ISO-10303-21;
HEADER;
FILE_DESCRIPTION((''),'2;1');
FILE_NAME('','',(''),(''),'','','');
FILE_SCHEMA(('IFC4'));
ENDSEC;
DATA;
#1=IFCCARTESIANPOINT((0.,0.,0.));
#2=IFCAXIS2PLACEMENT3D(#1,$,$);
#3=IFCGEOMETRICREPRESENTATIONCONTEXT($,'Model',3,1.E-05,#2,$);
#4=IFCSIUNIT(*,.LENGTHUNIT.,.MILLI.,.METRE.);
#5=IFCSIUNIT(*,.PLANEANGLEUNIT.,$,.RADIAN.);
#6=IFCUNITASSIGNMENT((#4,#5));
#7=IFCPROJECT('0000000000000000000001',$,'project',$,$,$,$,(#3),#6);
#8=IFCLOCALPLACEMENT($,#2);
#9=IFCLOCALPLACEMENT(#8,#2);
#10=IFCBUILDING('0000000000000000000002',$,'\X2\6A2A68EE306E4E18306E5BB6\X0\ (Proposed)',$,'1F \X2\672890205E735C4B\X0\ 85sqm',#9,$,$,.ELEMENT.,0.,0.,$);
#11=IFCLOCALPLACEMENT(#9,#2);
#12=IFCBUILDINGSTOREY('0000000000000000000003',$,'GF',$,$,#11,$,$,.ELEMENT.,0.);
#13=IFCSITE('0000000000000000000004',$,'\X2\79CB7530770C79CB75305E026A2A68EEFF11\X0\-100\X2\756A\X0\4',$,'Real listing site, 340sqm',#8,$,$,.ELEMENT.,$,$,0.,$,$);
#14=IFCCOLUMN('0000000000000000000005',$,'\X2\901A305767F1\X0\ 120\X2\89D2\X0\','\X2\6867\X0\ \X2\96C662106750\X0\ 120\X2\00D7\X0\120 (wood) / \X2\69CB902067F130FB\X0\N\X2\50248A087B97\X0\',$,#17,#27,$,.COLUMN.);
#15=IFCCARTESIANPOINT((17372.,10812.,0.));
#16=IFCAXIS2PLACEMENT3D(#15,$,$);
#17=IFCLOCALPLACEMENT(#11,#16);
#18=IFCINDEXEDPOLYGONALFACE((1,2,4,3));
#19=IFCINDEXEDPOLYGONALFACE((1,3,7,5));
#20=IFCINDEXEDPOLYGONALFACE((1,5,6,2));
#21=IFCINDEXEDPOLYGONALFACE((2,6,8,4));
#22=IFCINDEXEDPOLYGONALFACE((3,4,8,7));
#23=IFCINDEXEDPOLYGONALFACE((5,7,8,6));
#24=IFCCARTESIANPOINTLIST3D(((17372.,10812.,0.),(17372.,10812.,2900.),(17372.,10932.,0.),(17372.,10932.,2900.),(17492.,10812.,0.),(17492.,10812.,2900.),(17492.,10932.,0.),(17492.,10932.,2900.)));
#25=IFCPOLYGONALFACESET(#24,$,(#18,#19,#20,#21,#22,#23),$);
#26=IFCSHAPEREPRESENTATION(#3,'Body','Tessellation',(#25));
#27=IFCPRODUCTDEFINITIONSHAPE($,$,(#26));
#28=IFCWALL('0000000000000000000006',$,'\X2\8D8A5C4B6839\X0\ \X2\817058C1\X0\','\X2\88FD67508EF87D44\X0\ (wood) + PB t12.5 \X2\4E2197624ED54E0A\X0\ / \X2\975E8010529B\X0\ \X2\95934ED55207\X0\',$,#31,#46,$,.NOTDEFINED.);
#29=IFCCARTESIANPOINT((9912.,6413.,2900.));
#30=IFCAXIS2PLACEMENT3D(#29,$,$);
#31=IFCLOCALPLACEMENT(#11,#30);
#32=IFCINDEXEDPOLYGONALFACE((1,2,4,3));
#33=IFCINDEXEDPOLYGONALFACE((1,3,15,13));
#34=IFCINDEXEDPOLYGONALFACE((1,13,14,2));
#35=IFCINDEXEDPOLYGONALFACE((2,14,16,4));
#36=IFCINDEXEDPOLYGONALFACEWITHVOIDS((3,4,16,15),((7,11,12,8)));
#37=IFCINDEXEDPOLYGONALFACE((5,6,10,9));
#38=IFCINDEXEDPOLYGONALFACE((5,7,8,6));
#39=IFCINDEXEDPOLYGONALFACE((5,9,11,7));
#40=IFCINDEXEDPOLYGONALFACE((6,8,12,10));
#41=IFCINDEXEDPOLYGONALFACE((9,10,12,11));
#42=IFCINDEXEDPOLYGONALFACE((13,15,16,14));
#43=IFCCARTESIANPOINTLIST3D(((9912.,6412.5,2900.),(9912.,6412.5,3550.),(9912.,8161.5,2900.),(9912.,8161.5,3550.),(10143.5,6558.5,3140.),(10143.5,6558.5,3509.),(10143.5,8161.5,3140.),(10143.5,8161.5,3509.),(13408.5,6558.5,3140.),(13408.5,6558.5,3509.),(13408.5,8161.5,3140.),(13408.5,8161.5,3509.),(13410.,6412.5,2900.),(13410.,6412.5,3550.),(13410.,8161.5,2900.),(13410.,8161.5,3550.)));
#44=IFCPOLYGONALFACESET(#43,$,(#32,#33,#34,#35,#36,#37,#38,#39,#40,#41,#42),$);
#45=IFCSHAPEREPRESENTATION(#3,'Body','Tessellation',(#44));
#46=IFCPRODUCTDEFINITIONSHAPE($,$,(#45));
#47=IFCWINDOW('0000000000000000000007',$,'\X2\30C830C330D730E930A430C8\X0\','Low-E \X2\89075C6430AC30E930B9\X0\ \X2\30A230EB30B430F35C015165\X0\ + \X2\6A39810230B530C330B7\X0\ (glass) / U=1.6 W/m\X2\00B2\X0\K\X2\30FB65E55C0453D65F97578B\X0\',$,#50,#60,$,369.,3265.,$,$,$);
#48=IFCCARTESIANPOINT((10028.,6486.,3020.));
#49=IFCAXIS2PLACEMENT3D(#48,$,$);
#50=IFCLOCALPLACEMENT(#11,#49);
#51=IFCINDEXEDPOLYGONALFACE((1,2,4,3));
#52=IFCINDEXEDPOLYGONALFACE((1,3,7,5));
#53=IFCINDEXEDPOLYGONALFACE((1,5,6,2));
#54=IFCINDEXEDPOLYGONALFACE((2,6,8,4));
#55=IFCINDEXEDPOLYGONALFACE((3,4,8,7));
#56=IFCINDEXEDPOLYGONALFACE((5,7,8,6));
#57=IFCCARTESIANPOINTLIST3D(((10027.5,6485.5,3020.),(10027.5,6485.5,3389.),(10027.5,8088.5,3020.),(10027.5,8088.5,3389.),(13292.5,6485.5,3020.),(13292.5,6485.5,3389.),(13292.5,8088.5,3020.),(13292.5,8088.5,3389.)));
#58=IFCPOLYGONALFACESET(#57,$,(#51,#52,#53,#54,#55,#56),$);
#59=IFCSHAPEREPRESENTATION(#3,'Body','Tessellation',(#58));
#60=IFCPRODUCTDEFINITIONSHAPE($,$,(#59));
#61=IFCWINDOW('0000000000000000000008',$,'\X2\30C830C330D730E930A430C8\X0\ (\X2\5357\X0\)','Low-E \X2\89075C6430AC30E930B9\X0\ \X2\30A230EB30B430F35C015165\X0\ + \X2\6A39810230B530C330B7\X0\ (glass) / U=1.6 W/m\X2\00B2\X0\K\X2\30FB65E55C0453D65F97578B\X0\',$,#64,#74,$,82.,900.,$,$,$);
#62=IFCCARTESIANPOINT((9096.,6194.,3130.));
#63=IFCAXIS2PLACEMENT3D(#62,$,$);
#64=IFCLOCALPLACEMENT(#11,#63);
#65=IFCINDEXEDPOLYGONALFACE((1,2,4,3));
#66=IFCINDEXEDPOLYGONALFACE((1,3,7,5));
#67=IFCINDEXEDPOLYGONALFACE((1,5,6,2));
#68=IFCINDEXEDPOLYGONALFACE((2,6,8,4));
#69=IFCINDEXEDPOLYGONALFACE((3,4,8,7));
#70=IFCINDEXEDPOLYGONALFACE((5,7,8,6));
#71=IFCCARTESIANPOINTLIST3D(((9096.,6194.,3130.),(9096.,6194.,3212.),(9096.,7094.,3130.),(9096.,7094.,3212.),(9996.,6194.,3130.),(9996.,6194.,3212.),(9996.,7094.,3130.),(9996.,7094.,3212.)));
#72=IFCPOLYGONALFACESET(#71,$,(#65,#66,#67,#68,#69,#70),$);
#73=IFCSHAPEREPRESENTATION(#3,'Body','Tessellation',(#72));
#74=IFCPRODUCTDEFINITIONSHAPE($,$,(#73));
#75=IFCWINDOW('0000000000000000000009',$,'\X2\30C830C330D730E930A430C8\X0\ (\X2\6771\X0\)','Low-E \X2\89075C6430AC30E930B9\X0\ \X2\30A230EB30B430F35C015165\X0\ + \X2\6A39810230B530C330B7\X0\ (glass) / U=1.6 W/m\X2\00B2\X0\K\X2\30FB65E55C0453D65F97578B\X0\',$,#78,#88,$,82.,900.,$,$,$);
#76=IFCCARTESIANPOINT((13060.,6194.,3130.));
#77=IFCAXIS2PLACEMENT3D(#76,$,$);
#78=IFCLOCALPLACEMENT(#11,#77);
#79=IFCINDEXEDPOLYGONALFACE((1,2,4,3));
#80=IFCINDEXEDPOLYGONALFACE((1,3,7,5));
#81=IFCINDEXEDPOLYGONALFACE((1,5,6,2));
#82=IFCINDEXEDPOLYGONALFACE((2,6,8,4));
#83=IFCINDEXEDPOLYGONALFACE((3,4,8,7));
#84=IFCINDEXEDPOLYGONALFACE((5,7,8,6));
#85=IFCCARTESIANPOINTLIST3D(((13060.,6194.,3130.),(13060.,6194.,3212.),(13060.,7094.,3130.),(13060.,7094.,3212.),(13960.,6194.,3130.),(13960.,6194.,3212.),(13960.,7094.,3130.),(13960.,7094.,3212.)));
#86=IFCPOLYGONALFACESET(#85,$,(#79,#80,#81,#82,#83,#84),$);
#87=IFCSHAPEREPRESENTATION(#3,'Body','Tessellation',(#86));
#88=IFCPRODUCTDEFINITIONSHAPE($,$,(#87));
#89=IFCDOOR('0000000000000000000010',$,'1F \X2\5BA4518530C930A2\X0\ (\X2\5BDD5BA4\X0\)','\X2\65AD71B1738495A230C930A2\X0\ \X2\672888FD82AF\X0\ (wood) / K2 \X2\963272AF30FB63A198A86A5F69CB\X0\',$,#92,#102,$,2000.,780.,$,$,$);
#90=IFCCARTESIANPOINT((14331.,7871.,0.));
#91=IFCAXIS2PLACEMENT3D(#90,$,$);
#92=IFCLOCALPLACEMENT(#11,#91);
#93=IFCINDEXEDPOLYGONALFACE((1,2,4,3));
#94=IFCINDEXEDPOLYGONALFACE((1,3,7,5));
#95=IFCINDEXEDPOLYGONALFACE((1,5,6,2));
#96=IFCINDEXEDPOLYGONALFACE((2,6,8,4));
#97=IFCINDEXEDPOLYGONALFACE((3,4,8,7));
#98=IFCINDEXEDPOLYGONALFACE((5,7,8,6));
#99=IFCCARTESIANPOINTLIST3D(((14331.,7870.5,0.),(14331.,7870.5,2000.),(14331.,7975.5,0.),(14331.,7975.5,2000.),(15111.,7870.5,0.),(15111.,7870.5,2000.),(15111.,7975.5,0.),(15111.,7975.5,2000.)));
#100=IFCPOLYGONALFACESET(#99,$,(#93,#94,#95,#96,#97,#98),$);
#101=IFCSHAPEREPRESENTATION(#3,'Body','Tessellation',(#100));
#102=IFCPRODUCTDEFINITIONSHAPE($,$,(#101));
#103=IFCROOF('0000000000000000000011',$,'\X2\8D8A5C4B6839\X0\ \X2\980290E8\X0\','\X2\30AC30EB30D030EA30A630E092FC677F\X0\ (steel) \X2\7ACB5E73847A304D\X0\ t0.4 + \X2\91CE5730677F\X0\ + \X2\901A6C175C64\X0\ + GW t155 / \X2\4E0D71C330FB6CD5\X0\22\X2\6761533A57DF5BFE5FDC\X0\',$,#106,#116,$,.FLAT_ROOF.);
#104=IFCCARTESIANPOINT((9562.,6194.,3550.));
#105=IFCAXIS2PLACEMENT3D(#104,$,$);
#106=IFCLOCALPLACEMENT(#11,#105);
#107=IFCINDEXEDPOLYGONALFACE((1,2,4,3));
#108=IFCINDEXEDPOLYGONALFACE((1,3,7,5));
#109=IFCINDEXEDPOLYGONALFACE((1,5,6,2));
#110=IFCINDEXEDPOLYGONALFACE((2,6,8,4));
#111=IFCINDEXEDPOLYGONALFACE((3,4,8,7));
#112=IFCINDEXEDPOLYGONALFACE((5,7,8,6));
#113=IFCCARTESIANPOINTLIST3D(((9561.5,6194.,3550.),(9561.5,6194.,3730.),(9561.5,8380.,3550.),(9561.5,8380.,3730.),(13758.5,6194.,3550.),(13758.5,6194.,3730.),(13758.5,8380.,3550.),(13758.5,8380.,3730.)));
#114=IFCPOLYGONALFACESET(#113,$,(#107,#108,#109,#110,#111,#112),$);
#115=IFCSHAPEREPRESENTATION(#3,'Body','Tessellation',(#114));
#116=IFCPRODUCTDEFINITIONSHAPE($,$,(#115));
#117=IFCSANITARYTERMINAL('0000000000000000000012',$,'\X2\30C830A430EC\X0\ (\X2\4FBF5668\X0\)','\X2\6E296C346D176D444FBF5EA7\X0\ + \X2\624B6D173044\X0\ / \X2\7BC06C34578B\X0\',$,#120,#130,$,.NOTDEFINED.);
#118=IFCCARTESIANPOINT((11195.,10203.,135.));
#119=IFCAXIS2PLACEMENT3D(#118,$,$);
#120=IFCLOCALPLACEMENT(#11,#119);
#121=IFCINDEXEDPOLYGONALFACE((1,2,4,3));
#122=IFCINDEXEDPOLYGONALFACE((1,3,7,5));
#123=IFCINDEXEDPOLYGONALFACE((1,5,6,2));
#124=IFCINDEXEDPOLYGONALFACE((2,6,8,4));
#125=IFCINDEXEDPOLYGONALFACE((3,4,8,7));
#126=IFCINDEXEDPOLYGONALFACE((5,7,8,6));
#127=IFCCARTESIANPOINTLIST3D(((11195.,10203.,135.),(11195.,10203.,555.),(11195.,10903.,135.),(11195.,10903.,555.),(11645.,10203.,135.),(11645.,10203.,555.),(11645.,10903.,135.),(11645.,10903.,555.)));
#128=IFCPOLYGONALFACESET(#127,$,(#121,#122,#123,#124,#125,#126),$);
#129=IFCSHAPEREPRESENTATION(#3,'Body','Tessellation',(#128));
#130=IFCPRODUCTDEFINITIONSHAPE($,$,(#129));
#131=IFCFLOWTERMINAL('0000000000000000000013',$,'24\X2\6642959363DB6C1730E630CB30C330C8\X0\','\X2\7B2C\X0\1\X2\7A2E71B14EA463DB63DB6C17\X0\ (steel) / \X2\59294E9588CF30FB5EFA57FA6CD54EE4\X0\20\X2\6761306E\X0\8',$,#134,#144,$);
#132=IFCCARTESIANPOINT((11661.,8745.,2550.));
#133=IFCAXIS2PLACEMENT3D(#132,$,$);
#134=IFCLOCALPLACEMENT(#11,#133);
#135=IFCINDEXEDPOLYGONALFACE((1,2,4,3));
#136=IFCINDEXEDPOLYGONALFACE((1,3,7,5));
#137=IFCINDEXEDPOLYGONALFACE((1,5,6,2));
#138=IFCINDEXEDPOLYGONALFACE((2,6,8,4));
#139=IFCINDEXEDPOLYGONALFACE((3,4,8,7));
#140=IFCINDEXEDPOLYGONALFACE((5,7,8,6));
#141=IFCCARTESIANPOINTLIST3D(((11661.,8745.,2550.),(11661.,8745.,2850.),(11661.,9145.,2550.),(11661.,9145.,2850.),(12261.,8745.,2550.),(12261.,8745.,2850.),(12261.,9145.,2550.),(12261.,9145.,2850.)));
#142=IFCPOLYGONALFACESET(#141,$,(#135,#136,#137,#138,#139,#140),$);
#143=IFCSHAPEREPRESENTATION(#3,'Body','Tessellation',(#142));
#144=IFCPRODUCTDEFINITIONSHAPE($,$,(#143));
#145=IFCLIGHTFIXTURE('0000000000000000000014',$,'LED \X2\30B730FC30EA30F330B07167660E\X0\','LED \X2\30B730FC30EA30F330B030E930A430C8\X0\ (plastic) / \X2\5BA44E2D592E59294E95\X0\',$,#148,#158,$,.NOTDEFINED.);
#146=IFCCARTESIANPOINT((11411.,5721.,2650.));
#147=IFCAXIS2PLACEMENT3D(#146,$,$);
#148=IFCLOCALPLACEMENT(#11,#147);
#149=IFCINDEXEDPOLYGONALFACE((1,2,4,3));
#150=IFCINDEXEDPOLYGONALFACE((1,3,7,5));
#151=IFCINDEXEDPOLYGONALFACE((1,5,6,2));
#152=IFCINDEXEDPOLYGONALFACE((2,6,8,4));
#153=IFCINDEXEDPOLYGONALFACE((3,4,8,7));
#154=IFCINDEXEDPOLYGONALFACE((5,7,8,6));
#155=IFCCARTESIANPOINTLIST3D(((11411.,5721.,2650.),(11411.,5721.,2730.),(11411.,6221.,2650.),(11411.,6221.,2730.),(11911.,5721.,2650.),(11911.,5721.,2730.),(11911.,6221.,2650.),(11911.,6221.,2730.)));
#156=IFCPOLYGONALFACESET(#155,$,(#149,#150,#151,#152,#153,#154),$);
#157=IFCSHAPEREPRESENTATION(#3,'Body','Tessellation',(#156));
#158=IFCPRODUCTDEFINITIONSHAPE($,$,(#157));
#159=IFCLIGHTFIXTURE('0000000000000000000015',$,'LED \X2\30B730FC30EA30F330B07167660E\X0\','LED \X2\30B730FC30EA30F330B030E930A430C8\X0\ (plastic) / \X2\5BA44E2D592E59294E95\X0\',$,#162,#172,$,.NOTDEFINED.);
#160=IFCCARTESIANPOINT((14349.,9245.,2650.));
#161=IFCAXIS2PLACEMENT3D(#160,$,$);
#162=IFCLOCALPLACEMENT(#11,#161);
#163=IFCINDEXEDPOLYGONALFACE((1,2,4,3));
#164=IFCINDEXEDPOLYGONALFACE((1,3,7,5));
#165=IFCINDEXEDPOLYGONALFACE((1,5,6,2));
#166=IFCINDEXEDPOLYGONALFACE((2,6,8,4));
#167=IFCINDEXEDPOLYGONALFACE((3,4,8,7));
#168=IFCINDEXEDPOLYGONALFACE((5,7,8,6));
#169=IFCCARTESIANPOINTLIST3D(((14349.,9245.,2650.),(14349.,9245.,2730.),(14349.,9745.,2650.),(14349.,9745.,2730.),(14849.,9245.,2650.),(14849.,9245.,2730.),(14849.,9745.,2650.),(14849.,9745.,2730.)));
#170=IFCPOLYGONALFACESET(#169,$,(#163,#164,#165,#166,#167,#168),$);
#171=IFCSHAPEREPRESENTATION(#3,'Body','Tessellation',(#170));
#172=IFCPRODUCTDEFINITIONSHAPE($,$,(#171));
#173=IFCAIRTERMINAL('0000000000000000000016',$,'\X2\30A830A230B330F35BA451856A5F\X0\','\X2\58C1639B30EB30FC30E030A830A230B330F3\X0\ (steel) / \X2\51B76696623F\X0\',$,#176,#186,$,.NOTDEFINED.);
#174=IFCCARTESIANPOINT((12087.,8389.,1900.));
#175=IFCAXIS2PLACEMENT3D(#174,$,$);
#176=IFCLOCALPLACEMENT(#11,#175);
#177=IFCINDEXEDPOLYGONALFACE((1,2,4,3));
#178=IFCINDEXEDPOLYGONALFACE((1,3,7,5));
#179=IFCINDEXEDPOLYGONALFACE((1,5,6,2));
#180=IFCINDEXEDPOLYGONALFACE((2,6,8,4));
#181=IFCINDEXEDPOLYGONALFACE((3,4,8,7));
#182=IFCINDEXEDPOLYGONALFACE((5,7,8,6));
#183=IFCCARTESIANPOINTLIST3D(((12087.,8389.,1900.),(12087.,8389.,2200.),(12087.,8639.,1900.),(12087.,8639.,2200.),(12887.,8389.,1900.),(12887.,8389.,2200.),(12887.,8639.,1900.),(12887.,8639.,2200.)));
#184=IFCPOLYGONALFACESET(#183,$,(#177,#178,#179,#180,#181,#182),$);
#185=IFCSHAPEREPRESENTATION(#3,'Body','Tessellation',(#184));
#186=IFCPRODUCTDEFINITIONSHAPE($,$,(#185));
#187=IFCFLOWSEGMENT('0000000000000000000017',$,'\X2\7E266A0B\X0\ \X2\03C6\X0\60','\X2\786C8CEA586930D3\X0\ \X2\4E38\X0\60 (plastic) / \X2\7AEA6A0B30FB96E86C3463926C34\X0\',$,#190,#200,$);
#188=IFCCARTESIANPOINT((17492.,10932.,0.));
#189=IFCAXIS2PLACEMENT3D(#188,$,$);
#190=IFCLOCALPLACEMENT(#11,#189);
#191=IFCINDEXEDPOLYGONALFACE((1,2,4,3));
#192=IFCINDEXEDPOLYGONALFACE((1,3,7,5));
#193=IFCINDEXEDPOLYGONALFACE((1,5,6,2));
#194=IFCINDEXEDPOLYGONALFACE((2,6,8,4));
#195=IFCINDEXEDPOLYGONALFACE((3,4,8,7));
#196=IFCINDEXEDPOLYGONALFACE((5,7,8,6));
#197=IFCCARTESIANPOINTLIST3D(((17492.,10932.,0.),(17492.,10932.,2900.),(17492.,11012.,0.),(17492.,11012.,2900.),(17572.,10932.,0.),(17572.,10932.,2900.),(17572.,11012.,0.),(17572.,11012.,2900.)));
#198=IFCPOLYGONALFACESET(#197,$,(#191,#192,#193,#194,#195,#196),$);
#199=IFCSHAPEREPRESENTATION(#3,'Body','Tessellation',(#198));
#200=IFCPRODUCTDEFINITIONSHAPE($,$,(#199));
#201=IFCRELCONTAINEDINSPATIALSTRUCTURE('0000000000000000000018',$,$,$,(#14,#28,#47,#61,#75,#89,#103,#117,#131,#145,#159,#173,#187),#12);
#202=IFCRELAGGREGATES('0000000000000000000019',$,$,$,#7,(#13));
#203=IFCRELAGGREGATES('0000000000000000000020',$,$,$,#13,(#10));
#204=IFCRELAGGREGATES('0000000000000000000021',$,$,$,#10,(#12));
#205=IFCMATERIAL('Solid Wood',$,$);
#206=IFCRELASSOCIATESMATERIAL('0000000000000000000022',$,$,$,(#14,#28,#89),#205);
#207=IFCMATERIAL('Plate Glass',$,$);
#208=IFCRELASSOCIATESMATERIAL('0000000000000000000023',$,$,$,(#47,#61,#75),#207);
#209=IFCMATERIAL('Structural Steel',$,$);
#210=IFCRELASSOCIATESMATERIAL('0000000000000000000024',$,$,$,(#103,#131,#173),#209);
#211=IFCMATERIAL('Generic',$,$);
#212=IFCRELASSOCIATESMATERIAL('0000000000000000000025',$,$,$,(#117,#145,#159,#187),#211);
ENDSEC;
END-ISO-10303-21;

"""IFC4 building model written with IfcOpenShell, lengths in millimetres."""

from ifc_helpers import new_model, si_unit, frame, frame_2d, origin, place, context, project, spatial, rectangle, extrude, material, element, fill, save


model = new_model("IFC4")

# Units and contexts
model_context = context("Model", 3, precision=1e-05, world=origin())
ifc_project = project(units=[si_unit("LENGTHUNIT", "METRE", prefix="MILLI"), si_unit("PLANEANGLEUNIT", "RADIAN")], contexts=[model_context])

# Site, building, storey
site_placement = place(None, origin())
site = spatial("IfcSite", under=ifc_project, at=site_placement, Name="秋田県秋田市横森１-100番4", ObjectType="Real listing site, 340sqm", CompositionType="ELEMENT", RefElevation=0.0)
building_placement = place(site_placement, origin())
building = spatial("IfcBuilding", under=site, at=building_placement, Name="横森の丘の家 (Proposed)", ObjectType="1F 木造平屋 85sqm", CompositionType="ELEMENT", ElevationOfRefHeight=0.0, ElevationOfTerrain=0.0)
storey_placement = place(building_placement, origin())
storey = spatial("IfcBuildingStorey", under=building, at=storey_placement, Name="GF", CompositionType="ELEMENT", Elevation=0.0)

# Column
ifc_material_1 = material(Name="Solid Wood")
column_1_placement = place(storey_placement, frame((17372.0, 10812.0, 0.0)))
element("IfcColumn", 1, at=column_1_placement, inside=storey, material=ifc_material_1, Name="通し柱 120角", Description="桧 集成材 120×120 (wood) / 構造柱・N値計算", PredefinedType="COLUMN", context=model_context, shape_type="SweptSolid", body=[
    extrude(rectangle(XDim=120.0, YDim=120.0, at=frame_2d((60.0, 60.0))), frame((17372.0, 10812.0, 0.0)), (0.0, 0.0, 1.0), 2900.0),
])

# Wall, openings, windows
wall_1_placement = place(storey_placement, frame((9912.0, 6413.0, 2900.0)))
wall_1 = element("IfcWall", 2, at=wall_1_placement, inside=storey, material=ifc_material_1, Name="越屋根 腰壁", Description="製材軸組 (wood) + PB t12.5 両面仕上 / 非耐力 間仕切", PredefinedType="NOTDEFINED", context=model_context, shape_type="SweptSolid", body=[
    extrude(rectangle(XDim=3498.0, YDim=1749.0, at=frame_2d((1749.0, 874.0))), frame((9912.0, 6413.0, 2900.0)), (0.0, 0.0, 1.0), 650.0),
])
opening_1_placement = place(storey_placement, frame((10028.0, 6486.0, 3020.0)))
opening_1 = element("IfcOpeningElement", 3, at=opening_1_placement, cuts=wall_1, PredefinedType="NOTDEFINED", context=model_context, shape_type="SweptSolid", body=[
    extrude(rectangle(XDim=3265.0, YDim=1603.0, at=frame_2d((1632.0, 801.0))), frame((10028.0, 6486.0, 3020.0)), (0.0, 0.0, 1.0), 369.0),
])
opening_2_placement = place(storey_placement, frame((9096.0, 6194.0, 3130.0)))
opening_2 = element("IfcOpeningElement", 4, at=opening_2_placement, cuts=wall_1, PredefinedType="NOTDEFINED", context=model_context, shape_type="SweptSolid", body=[
    extrude(rectangle(XDim=900.0, YDim=900.0, at=frame_2d((450.0, 450.0))), frame((9096.0, 6194.0, 3130.0)), (0.0, 0.0, 1.0), 82.0),
])
opening_3_placement = place(storey_placement, frame((13060.0, 6194.0, 3130.0)))
opening_3 = element("IfcOpeningElement", 5, at=opening_3_placement, cuts=wall_1, PredefinedType="NOTDEFINED", context=model_context, shape_type="SweptSolid", body=[
    extrude(rectangle(XDim=900.0, YDim=900.0, at=frame_2d((450.0, 450.0))), frame((13060.0, 6194.0, 3130.0)), (0.0, 0.0, 1.0), 82.0),
])
ifc_material_2 = material(Name="Plate Glass")
window_1_placement = place(storey_placement, frame((10028.0, 6486.0, 3020.0)))
window_1 = element("IfcWindow", 6, at=window_1_placement, inside=storey, material=ifc_material_2, Name="トップライト", Description="Low-E 複層ガラス アルゴン封入 + 樹脂サッシ (glass) / U=1.6 W/m²K・日射取得型", OverallHeight=369.0, OverallWidth=3265.0, context=model_context, shape_type="SweptSolid", body=[
    extrude(rectangle(XDim=3265.0, YDim=1603.0, at=frame_2d((1632.0, 801.0))), frame((10028.0, 6486.0, 3020.0)), (0.0, 0.0, 1.0), 369.0),
])
fill(opening_1, window_1)
window_2_placement = place(storey_placement, frame((9096.0, 6194.0, 3130.0)))
window_2 = element("IfcWindow", 7, at=window_2_placement, inside=storey, material=ifc_material_2, Name="トップライト (南)", Description="Low-E 複層ガラス アルゴン封入 + 樹脂サッシ (glass) / U=1.6 W/m²K・日射取得型", OverallHeight=82.0, OverallWidth=900.0, context=model_context, shape_type="SweptSolid", body=[
    extrude(rectangle(XDim=900.0, YDim=900.0, at=frame_2d((450.0, 450.0))), frame((9096.0, 6194.0, 3130.0)), (0.0, 0.0, 1.0), 82.0),
])
fill(opening_2, window_2)
window_3_placement = place(storey_placement, frame((13060.0, 6194.0, 3130.0)))
window_3 = element("IfcWindow", 8, at=window_3_placement, inside=storey, material=ifc_material_2, Name="トップライト (東)", Description="Low-E 複層ガラス アルゴン封入 + 樹脂サッシ (glass) / U=1.6 W/m²K・日射取得型", OverallHeight=82.0, OverallWidth=900.0, context=model_context, shape_type="SweptSolid", body=[
    extrude(rectangle(XDim=900.0, YDim=900.0, at=frame_2d((450.0, 450.0))), frame((13060.0, 6194.0, 3130.0)), (0.0, 0.0, 1.0), 82.0),
])
fill(opening_3, window_3)

# Door
door_placement = place(storey_placement, frame((14331.0, 7871.0, 0.0)))
element("IfcDoor", 9, at=door_placement, inside=storey, material=ifc_material_1, Name="1F 室内ドア (寝室)", Description="断熱玄関ドア 木製芯 (wood) / K2 防犯・採風機構", OverallHeight=2000.0, OverallWidth=780.0, context=model_context, shape_type="SweptSolid", body=[
    extrude(rectangle(XDim=780.0, YDim=105.0, at=frame_2d((390.0, 52.0))), frame((14331.0, 7871.0, 0.0)), (0.0, 0.0, 1.0), 2000.0),
])

# Roof
ifc_material_3 = material(Name="Structural Steel")
roof_placement = place(storey_placement, frame((9562.0, 6194.0, 3550.0)))
element("IfcRoof", 10, at=roof_placement, inside=storey, material=ifc_material_3, Name="越屋根 頂部", Description="ガルバリウム鋼板 (steel) 立平葺き t0.4 + 野地板 + 通気層 + GW t155 / 不燃・法22条区域対応", PredefinedType="FLAT_ROOF", context=model_context, shape_type="SweptSolid", body=[
    extrude(rectangle(XDim=4197.0, YDim=2186.0, at=frame_2d((2098.0, 1093.0))), frame((9562.0, 6194.0, 3550.0)), (0.0, 0.0, 1.0), 180.0),
])

# Sanitary terminal
ifc_material_4 = material(Name="Generic")
sanitary_terminal_placement = place(storey_placement, frame((11195.0, 10203.0, 135.0)))
element("IfcSanitaryTerminal", 11, at=sanitary_terminal_placement, inside=storey, material=ifc_material_4, Name="トイレ (便器)", Description="温水洗浄便座 + 手洗い / 節水型", PredefinedType="NOTDEFINED", context=model_context, shape_type="SweptSolid", body=[
    extrude(rectangle(XDim=450.0, YDim=700.0, at=frame_2d((225.0, 350.0))), frame((11195.0, 10203.0, 135.0)), (0.0, 0.0, 1.0), 420.0),
])

# Flow terminal
flow_terminal_placement = place(storey_placement, frame((11661.0, 8745.0, 2550.0)))
element("IfcFlowTerminal", 12, at=flow_terminal_placement, inside=storey, material=ifc_material_3, Name="24時間換気ユニット", Description="第1種熱交換換気 (steel) / 天井裏・建基法令20条の8", context=model_context, shape_type="SweptSolid", body=[
    extrude(rectangle(XDim=600.0, YDim=400.0, at=frame_2d((300.0, 200.0))), frame((11661.0, 8745.0, 2550.0)), (0.0, 0.0, 1.0), 300.0),
])

# Light fixtures
light_fixture_1_placement = place(storey_placement, frame((11411.0, 5721.0, 2650.0)))
element("IfcLightFixture", 13, at=light_fixture_1_placement, inside=storey, material=ifc_material_4, Name="LED シーリング照明", Description="LED シーリングライト (plastic) / 室中央天井", PredefinedType="NOTDEFINED", context=model_context, shape_type="SweptSolid", body=[
    extrude(rectangle(XDim=500.0, YDim=500.0, at=frame_2d((250.0, 250.0))), frame((11411.0, 5721.0, 2650.0)), (0.0, 0.0, 1.0), 80.0),
])
light_fixture_2_placement = place(storey_placement, frame((14349.0, 9245.0, 2650.0)))
element("IfcLightFixture", 14, at=light_fixture_2_placement, inside=storey, material=ifc_material_4, Name="LED シーリング照明", Description="LED シーリングライト (plastic) / 室中央天井", PredefinedType="NOTDEFINED", context=model_context, shape_type="SweptSolid", body=[
    extrude(rectangle(XDim=500.0, YDim=500.0, at=frame_2d((250.0, 250.0))), frame((14349.0, 9245.0, 2650.0)), (0.0, 0.0, 1.0), 80.0),
])

# Air terminal
air_terminal_placement = place(storey_placement, frame((12087.0, 8389.0, 1900.0)))
element("IfcAirTerminal", 15, at=air_terminal_placement, inside=storey, material=ifc_material_3, Name="エアコン室内機", Description="壁掛ルームエアコン (steel) / 冷暖房", PredefinedType="NOTDEFINED", context=model_context, shape_type="SweptSolid", body=[
    extrude(rectangle(XDim=800.0, YDim=250.0, at=frame_2d((400.0, 125.0))), frame((12087.0, 8389.0, 1900.0)), (0.0, 0.0, 1.0), 300.0),
])

# Flow segment
flow_segment_placement = place(storey_placement, frame((17492.0, 10932.0, 0.0)))
element("IfcFlowSegment", 16, at=flow_segment_placement, inside=storey, material=ifc_material_4, Name="縦樋 φ60", Description="硬質塩ビ 丸60 (plastic) / 竪樋・雨水排水", context=model_context, shape_type="SweptSolid", body=[
    extrude(rectangle(XDim=80.0, YDim=80.0, at=frame_2d((40.0, 40.0))), frame((17492.0, 10932.0, 0.0)), (0.0, 0.0, 1.0), 2900.0),
])

save(model, "model.ifc")
